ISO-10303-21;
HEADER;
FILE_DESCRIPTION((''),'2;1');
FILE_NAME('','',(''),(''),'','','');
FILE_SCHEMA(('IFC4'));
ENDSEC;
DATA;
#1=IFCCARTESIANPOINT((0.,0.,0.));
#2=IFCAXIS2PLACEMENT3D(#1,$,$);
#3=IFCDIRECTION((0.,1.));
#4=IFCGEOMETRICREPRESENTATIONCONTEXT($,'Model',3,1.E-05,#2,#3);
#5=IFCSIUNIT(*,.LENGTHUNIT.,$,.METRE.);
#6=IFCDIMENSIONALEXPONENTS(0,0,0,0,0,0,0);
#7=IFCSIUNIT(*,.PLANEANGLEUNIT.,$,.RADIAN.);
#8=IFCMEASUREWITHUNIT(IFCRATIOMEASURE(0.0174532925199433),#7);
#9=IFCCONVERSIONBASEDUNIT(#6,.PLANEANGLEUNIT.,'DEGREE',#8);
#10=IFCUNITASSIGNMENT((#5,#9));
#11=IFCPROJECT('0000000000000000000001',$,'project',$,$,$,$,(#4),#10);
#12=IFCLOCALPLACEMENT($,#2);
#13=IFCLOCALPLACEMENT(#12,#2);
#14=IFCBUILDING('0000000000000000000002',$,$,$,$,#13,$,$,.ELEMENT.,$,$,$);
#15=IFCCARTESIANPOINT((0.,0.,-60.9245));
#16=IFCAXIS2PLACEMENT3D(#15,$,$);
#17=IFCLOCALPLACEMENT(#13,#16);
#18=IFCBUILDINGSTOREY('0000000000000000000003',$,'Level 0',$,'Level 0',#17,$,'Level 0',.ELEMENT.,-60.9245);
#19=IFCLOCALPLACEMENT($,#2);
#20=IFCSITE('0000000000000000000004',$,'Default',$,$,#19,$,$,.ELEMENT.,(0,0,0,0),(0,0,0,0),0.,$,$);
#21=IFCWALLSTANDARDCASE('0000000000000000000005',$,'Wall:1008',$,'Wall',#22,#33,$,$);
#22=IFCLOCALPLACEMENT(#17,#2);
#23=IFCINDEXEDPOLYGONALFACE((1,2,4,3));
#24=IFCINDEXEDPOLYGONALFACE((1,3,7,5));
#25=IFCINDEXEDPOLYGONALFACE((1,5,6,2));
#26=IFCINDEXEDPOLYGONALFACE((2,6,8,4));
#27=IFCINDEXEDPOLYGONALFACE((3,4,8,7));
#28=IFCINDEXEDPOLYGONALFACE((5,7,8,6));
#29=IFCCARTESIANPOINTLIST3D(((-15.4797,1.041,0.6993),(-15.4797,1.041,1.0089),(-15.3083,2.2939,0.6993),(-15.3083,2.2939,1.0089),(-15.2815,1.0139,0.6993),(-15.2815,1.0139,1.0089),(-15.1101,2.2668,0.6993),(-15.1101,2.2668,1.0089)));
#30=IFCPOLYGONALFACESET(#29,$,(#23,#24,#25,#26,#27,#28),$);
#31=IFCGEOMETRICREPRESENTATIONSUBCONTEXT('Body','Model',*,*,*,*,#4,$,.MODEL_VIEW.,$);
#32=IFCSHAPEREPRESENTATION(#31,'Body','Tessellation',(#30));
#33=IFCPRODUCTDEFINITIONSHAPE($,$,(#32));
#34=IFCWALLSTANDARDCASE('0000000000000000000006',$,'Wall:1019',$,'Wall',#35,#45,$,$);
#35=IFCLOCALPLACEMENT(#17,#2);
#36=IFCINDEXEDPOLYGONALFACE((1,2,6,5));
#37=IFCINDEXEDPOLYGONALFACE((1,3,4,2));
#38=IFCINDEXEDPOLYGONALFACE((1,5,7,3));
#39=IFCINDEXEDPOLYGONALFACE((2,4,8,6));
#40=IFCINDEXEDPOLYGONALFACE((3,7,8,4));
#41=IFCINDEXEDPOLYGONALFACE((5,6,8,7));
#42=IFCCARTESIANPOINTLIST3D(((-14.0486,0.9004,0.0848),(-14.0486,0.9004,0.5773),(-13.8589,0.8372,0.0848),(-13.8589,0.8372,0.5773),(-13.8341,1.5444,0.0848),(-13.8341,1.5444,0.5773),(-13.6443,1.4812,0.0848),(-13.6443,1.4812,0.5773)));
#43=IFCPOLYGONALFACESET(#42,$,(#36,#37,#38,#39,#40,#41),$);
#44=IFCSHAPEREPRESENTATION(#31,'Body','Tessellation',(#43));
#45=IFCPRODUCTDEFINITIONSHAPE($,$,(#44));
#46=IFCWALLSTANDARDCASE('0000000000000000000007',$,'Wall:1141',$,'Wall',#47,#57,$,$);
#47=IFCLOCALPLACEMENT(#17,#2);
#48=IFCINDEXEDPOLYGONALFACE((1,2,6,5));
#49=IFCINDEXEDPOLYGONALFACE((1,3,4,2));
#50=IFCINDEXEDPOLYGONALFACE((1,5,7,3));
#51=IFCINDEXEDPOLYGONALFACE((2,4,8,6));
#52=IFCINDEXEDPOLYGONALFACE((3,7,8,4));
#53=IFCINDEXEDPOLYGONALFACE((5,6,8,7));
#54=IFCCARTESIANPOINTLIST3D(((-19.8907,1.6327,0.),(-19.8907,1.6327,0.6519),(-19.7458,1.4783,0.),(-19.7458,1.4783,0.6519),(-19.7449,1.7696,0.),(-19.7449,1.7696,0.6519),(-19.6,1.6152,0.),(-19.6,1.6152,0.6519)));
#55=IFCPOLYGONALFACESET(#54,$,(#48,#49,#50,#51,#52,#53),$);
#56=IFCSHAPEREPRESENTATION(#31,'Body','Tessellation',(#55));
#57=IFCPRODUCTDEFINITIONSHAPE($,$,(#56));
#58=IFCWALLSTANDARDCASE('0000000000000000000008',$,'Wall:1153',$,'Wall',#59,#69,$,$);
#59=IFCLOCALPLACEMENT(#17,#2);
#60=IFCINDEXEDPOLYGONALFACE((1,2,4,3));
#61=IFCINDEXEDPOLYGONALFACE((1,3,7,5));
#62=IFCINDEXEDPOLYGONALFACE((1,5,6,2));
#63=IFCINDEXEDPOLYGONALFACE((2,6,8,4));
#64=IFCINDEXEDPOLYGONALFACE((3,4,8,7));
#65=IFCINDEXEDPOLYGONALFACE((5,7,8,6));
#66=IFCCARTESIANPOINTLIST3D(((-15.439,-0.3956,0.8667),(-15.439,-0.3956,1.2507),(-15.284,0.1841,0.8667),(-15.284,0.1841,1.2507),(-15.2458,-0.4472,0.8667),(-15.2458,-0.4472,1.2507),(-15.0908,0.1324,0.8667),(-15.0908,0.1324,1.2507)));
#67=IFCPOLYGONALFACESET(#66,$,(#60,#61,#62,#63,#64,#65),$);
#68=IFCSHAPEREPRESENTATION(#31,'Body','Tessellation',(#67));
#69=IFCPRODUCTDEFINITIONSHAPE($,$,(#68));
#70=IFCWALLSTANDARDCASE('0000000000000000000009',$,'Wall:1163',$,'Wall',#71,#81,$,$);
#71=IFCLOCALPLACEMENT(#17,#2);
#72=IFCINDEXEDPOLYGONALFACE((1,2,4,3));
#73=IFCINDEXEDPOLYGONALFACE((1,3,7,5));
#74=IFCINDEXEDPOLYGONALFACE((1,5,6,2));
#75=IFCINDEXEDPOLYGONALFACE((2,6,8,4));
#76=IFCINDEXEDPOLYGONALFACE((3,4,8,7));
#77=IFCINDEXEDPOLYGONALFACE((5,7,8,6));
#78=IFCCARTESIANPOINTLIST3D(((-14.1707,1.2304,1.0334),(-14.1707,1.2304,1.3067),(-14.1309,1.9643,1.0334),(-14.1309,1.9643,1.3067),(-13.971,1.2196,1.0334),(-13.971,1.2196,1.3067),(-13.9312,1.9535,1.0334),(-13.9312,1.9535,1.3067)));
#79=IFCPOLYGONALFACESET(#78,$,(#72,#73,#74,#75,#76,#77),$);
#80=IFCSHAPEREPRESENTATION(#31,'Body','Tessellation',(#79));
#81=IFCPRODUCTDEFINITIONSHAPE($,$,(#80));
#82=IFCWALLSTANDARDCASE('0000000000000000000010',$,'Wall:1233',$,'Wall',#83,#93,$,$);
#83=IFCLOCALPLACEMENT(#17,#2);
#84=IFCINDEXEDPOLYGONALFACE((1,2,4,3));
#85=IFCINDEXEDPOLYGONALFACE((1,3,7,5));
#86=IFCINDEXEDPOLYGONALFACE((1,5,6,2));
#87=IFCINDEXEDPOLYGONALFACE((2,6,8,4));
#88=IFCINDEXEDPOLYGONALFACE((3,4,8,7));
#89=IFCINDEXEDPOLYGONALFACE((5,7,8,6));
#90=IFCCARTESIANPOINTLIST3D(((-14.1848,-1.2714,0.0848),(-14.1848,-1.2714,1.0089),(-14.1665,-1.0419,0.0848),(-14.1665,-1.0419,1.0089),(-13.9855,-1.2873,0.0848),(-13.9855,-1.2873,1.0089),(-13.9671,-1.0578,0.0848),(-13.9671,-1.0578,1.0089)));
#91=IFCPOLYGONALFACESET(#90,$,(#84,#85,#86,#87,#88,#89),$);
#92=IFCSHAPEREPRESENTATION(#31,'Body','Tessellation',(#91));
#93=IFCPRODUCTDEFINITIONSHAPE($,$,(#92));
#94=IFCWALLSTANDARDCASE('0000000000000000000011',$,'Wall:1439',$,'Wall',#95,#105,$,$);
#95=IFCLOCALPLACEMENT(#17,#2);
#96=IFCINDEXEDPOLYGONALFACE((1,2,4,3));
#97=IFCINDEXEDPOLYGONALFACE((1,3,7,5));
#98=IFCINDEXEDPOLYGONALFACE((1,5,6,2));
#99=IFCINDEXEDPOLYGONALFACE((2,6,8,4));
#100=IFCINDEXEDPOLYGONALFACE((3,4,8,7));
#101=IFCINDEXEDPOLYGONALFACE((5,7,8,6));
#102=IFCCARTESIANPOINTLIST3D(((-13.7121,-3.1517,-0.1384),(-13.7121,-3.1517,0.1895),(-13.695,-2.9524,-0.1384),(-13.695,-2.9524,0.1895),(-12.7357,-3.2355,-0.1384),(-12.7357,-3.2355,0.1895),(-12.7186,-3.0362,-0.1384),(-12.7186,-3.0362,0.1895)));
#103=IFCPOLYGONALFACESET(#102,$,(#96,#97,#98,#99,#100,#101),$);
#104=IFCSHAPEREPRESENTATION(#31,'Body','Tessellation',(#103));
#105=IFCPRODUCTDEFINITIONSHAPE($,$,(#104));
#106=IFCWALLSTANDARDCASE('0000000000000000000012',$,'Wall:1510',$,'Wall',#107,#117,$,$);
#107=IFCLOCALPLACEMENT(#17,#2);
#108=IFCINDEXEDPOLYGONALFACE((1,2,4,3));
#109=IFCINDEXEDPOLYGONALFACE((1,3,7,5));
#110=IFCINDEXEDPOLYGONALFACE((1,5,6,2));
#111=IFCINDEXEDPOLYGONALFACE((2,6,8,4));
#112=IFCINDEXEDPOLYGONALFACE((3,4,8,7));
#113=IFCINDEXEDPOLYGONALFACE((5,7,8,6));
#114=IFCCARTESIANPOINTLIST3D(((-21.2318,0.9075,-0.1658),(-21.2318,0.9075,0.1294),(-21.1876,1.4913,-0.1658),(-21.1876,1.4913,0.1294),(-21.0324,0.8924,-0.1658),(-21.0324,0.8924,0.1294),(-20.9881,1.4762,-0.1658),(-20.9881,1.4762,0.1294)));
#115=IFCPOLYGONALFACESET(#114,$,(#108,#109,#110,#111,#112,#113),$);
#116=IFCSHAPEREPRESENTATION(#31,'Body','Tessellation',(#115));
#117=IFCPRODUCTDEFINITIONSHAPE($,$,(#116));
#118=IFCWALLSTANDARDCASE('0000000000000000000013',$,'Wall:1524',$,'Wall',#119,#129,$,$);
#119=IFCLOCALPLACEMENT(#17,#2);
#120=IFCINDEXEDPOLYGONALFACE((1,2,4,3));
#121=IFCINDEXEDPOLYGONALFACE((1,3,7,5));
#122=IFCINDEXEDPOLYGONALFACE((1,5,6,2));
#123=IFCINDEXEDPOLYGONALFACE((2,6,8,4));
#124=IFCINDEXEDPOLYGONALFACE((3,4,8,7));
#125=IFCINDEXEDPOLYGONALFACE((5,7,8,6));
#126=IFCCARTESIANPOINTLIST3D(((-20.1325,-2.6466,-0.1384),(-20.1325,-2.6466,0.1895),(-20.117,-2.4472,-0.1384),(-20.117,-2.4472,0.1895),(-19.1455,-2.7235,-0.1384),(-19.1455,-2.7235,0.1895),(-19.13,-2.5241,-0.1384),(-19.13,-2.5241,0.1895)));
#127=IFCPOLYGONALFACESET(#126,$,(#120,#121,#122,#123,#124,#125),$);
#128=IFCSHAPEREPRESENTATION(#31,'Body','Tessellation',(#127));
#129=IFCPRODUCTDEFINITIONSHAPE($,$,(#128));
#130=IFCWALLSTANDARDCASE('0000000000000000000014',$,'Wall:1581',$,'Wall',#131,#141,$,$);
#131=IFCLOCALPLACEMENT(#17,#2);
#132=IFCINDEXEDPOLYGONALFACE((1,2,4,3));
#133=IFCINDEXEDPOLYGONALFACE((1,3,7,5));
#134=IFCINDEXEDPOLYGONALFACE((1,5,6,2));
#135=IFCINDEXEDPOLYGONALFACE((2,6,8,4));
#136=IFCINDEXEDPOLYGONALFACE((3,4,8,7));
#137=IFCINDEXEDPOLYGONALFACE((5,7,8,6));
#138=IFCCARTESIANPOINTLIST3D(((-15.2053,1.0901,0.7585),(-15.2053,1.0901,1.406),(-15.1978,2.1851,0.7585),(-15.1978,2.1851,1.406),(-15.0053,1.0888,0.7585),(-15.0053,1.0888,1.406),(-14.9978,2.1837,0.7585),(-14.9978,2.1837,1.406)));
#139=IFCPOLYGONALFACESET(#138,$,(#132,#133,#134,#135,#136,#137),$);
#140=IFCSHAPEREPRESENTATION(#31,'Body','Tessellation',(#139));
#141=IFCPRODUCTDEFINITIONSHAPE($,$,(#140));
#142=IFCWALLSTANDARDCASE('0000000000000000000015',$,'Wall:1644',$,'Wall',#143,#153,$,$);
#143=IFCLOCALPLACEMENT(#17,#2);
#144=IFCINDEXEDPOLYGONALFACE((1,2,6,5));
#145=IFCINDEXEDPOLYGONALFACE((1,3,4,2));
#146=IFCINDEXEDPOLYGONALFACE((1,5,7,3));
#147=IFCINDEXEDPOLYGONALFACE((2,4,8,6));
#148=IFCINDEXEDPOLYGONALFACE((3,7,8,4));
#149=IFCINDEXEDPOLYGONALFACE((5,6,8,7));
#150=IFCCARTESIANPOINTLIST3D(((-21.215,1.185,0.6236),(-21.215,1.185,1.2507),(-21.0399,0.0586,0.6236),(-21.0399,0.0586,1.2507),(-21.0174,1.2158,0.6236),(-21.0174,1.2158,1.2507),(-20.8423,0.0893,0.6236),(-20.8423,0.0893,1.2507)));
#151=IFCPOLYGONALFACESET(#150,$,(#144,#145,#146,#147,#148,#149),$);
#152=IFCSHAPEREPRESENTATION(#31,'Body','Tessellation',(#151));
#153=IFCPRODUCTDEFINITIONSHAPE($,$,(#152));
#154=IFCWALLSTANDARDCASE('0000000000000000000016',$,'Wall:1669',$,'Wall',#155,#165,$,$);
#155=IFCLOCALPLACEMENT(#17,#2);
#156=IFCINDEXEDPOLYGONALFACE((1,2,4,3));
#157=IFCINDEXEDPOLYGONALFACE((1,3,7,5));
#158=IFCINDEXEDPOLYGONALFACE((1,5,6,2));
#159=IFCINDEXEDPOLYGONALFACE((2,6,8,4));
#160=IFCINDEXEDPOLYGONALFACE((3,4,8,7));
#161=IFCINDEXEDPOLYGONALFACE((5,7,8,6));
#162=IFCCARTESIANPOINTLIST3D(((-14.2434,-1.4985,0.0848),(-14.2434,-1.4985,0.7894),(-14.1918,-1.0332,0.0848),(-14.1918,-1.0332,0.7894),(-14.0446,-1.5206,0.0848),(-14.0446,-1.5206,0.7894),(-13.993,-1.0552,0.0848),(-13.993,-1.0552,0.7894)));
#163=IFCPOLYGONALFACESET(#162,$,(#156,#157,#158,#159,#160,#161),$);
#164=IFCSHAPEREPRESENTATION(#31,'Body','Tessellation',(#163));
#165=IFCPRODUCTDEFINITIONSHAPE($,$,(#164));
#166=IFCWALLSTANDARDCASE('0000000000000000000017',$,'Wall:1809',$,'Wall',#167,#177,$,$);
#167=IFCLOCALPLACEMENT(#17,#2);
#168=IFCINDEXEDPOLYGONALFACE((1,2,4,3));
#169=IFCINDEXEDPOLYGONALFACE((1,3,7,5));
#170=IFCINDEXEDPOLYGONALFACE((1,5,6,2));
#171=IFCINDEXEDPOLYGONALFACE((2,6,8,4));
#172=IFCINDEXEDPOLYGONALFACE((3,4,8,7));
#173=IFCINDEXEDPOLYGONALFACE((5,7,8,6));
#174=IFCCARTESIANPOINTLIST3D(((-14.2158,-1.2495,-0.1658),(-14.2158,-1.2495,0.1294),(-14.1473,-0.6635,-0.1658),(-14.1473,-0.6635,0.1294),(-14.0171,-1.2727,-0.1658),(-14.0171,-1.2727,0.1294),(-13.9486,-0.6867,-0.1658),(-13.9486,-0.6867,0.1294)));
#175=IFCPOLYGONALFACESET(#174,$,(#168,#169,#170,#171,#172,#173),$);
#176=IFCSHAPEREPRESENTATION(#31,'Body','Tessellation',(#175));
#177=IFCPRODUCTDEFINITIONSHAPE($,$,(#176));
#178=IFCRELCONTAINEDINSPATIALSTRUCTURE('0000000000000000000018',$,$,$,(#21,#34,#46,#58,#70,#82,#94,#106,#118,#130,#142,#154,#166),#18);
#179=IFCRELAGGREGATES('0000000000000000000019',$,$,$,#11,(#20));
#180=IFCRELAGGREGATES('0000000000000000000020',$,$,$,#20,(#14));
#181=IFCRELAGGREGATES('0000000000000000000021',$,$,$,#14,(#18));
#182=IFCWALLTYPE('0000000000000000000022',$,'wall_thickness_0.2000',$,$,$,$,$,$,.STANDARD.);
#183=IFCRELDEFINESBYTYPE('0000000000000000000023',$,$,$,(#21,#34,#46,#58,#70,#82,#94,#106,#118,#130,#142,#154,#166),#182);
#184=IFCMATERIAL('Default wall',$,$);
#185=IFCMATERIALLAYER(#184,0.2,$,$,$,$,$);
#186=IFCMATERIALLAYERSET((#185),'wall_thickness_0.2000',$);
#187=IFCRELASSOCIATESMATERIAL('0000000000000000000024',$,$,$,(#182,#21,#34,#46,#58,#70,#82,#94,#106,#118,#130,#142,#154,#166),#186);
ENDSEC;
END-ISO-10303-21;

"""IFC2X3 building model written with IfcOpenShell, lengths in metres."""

from ifc_helpers import new_model, entity, si_unit, converted_unit, direction, frame, origin, place, context, subcontext, project, spatial, polyline, outline, extrude, material, layer, layer_set, layer_usage, type_object, element, save


model = new_model("IFC2X3")

# Units and contexts
model_context = context("Model", 3, precision=1e-05, world=origin(), true_north=direction((0.0, 1.0)))
body_context = subcontext(model_context, "Body", "Model", "MODEL_VIEW")
ifc_project = project(units=[si_unit("LENGTHUNIT", "METRE"), converted_unit("PLANEANGLEUNIT", "DEGREE", entity("IfcRatioMeasure", 0.0174532925199433), si_unit("PLANEANGLEUNIT", "RADIAN"), dimensions=[0, 0, 0, 0, 0, 0, 0])], contexts=[model_context])

# Site, building, storey
site_placement = place(None, origin())
site = spatial("IfcSite", under=ifc_project, at=site_placement, Name="Default", CompositionType="ELEMENT", RefLatitude=(0, 0, 0, 0), RefLongitude=(0, 0, 0, 0), RefElevation=0.0)
placement_1 = place(None, origin())
building_placement = place(placement_1, origin())
building = spatial("IfcBuilding", under=site, at=building_placement, CompositionType="ELEMENT")
storey_placement = place(building_placement, frame((0.0, 0.0, -60.9245)))
storey = spatial("IfcBuildingStorey", under=building, at=storey_placement, Name="Level 0", ObjectType="Level 0", LongName="Level 0", CompositionType="ELEMENT", Elevation=-60.9245)

# Walls
ifc_material = material(Name="Default wall")
ifc_layer = layer(ifc_material, 0.2)
ifc_layer_set = layer_set([ifc_layer], Name="wall_thickness_0.2000")
ifc_layer_usage = layer_usage(ifc_layer_set, "AXIS2", "POSITIVE", -0.1)
wall_type = type_object("IfcWallType", Name="wall_thickness_0.2000", PredefinedType="STANDARD", material=ifc_layer_set)
placement_2 = place(building_placement, frame((0.0, 0.0, -60.2252)))
wall_1_placement = place(placement_2, frame((-15.3806, 1.0274, 0.0), z_axis=(0.0, 0.0, 1.0), x_axis=(0.135518, 0.990775, 0.0)))
element("IfcWallStandardCase", 1, at=wall_1_placement, inside=storey, type_object=wall_type, material=ifc_layer_usage, Name="Wall:1008", ObjectType="Wall", context=body_context, shape_type="SweptSolid", body=[
    extrude(outline(polyline([(1.2646, -0.1), (1.2646, 0.1), (0.0, 0.1), (0.0, -0.1), (1.2646, -0.1)])), origin(), (0.0, 0.0, 1.0), 0.3097),
])
placement_3 = place(building_placement, frame((0.0, 0.0, -60.8397)))
wall_2_placement = place(placement_3, frame((-13.9537, 0.8688, 0.0), z_axis=(0.0, 0.0, 1.0), x_axis=(0.316016, 0.948754, 0.0)))
element("IfcWallStandardCase", 2, at=wall_2_placement, inside=storey, type_object=wall_type, material=ifc_layer_usage, Name="Wall:1019", ObjectType="Wall", context=body_context, shape_type="SweptSolid", body=[
    extrude(outline(polyline([(0.6788, -0.1), (0.6788, 0.1), (0.0, 0.1), (0.0, -0.1), (0.6788, -0.1)])), origin(), (0.0, 0.0, 1.0), 0.4925),
])
wall_3_placement = place(storey_placement, frame((-19.6729, 1.5467, 0.0), z_axis=(0.0, 0.0, 1.0), x_axis=(-0.684278, 0.729221, 0.0)))
element("IfcWallStandardCase", 3, at=wall_3_placement, inside=storey, type_object=wall_type, material=ifc_layer_usage, Name="Wall:1141", ObjectType="Wall", context=body_context, shape_type="SweptSolid", body=[
    extrude(outline(polyline([(0.2118, -0.1), (0.2118, 0.1), (0.0, 0.1), (0.0, -0.1), (0.2118, -0.1)])), origin(), (0.0, 0.0, 1.0), 0.6519),
])
placement_4 = place(building_placement, frame((0.0, 0.0, -60.0578)))
wall_4_placement = place(placement_4, frame((-15.3424, -0.4214, 0.0), z_axis=(0.0, 0.0, 1.0), x_axis=(0.258331, 0.966056, 0.0)))
element("IfcWallStandardCase", 4, at=wall_4_placement, inside=storey, type_object=wall_type, material=ifc_layer_usage, Name="Wall:1153", ObjectType="Wall", context=body_context, shape_type="SweptSolid", body=[
    extrude(outline(polyline([(0.6, -0.1), (0.6, 0.1), (0.0, 0.1), (0.0, -0.1), (0.6, -0.1)])), origin(), (0.0, 0.0, 1.0), 0.384),
])
placement_5 = place(building_placement, frame((0.0, 0.0, -59.8911)))
wall_5_placement = place(placement_5, frame((-14.0709, 1.225, 0.0), z_axis=(0.0, 0.0, 1.0), x_axis=(0.054192, 0.998531, 0.0)))
element("IfcWallStandardCase", 5, at=wall_5_placement, inside=storey, type_object=wall_type, material=ifc_layer_usage, Name="Wall:1163", ObjectType="Wall", context=body_context, shape_type="SweptSolid", body=[
    extrude(outline(polyline([(0.735, -0.1), (0.735, 0.1), (0.0, 0.1), (0.0, -0.1), (0.735, -0.1)])), origin(), (0.0, 0.0, 1.0), 0.2734),
])
placement_6 = place(building_placement, frame((0.0, 0.0, -60.8397)))
wall_6_placement = place(placement_6, frame((-14.0852, -1.2794, 0.0), z_axis=(0.0, 0.0, 1.0), x_axis=(0.07964, 0.996824, 0.0)))
element("IfcWallStandardCase", 6, at=wall_6_placement, inside=storey, type_object=wall_type, material=ifc_layer_usage, Name="Wall:1233", ObjectType="Wall", context=body_context, shape_type="SweptSolid", body=[
    extrude(outline(polyline([(0.2303, -0.1), (0.2303, 0.1), (0.0, 0.1), (0.0, -0.1), (0.2303, -0.1)])), origin(), (0.0, 0.0, 1.0), 0.9242),
])
placement_7 = place(building_placement, frame((0.0, 0.0, -61.0629)))
wall_7_placement = place(placement_7, frame((-13.7035, -3.0521, 0.0), z_axis=(0.0, 0.0, 1.0), x_axis=(0.996336, -0.085528, 0.0)))
element("IfcWallStandardCase", 7, at=wall_7_placement, inside=storey, type_object=wall_type, material=ifc_layer_usage, Name="Wall:1439", ObjectType="Wall", context=body_context, shape_type="SweptSolid", body=[
    extrude(outline(polyline([(0.98, -0.1), (0.98, 0.1), (0.0, 0.1), (0.0, -0.1), (0.98, -0.1)])), origin(), (0.0, 0.0, 1.0), 0.3279),
])
placement_8 = place(building_placement, frame((0.0, 0.0, -61.0903)))
wall_8_placement = place(placement_8, frame((-21.0878, 1.4837, 0.0), z_axis=(0.0, 0.0, 1.0), x_axis=(-0.075583, -0.99714, 0.0)))
element("IfcWallStandardCase", 8, at=wall_8_placement, inside=storey, type_object=wall_type, material=ifc_layer_usage, Name="Wall:1510", ObjectType="Wall", context=body_context, shape_type="SweptSolid", body=[
    extrude(outline(polyline([(0.5855, -0.1), (0.5855, 0.1), (0.0, 0.1), (0.0, -0.1), (0.5855, -0.1)])), origin(), (0.0, 0.0, 1.0), 0.2952),
])
placement_9 = place(building_placement, frame((0.0, 0.0, -61.0629)))
wall_9_placement = place(placement_9, frame((-20.1248, -2.5469, 0.0), z_axis=(0.0, 0.0, 1.0), x_axis=(0.996982, -0.07763, 0.0)))
element("IfcWallStandardCase", 9, at=wall_9_placement, inside=storey, type_object=wall_type, material=ifc_layer_usage, Name="Wall:1524", ObjectType="Wall", context=body_context, shape_type="SweptSolid", body=[
    extrude(outline(polyline([(0.99, -0.1), (0.99, 0.1), (0.0, 0.1), (0.0, -0.1), (0.99, -0.1)])), origin(), (0.0, 0.0, 1.0), 0.3279),
])
placement_10 = place(building_placement, frame((0.0, 0.0, -60.166)))
wall_10_placement = place(placement_10, frame((-15.1053, 1.0894, 0.0), z_axis=(0.0, 0.0, 1.0), x_axis=(0.006875, 0.999976, 0.0)))
element("IfcWallStandardCase", 10, at=wall_10_placement, inside=storey, type_object=wall_type, material=ifc_layer_usage, Name="Wall:1581", ObjectType="Wall", context=body_context, shape_type="SweptSolid", body=[
    extrude(outline(polyline([(1.095, -0.1), (1.095, 0.1), (0.0, 0.1), (0.0, -0.1), (1.095, -0.1)])), origin(), (0.0, 0.0, 1.0), 0.6475),
])
placement_11 = place(building_placement, frame((0.0, 0.0, -60.3009)))
wall_11_placement = place(placement_11, frame((-21.1162, 1.2004, 0.0), z_axis=(0.0, 0.0, 1.0), x_axis=(0.153608, -0.988132, 0.0)))
element("IfcWallStandardCase", 11, at=wall_11_placement, inside=storey, type_object=wall_type, material=ifc_layer_usage, Name="Wall:1644", ObjectType="Wall", context=body_context, shape_type="SweptSolid", body=[
    extrude(outline(polyline([(1.14, -0.1), (1.14, 0.1), (0.0, 0.1), (0.0, -0.1), (1.14, -0.1)])), origin(), (0.0, 0.0, 1.0), 0.6271),
])
placement_12 = place(building_placement, frame((0.0, 0.0, -60.8397)))
wall_12_placement = place(placement_12, frame((-14.144, -1.5095, 0.0), z_axis=(0.0, 0.0, 1.0), x_axis=(0.110261, 0.993903, 0.0)))
element("IfcWallStandardCase", 12, at=wall_12_placement, inside=storey, type_object=wall_type, material=ifc_layer_usage, Name="Wall:1669", ObjectType="Wall", context=body_context, shape_type="SweptSolid", body=[
    extrude(outline(polyline([(0.4682, -0.1), (0.4682, 0.1), (0.0, 0.1), (0.0, -0.1), (0.4682, -0.1)])), origin(), (0.0, 0.0, 1.0), 0.7047),
])
placement_13 = place(building_placement, frame((0.0, 0.0, -61.0903)))
wall_13_placement = place(placement_13, frame((-14.0479, -0.6751, 0.0), z_axis=(0.0, 0.0, 1.0), x_axis=(-0.116146, -0.993232, 0.0)))
element("IfcWallStandardCase", 13, at=wall_13_placement, inside=storey, type_object=wall_type, material=ifc_layer_usage, Name="Wall:1809", ObjectType="Wall", context=body_context, shape_type="SweptSolid", body=[
    extrude(outline(polyline([(0.59, -0.1), (0.59, 0.1), (0.0, 0.1), (0.0, -0.1), (0.59, -0.1)])), origin(), (0.0, 0.0, 1.0), 0.2952),
])

save(model, "model.ifc")
